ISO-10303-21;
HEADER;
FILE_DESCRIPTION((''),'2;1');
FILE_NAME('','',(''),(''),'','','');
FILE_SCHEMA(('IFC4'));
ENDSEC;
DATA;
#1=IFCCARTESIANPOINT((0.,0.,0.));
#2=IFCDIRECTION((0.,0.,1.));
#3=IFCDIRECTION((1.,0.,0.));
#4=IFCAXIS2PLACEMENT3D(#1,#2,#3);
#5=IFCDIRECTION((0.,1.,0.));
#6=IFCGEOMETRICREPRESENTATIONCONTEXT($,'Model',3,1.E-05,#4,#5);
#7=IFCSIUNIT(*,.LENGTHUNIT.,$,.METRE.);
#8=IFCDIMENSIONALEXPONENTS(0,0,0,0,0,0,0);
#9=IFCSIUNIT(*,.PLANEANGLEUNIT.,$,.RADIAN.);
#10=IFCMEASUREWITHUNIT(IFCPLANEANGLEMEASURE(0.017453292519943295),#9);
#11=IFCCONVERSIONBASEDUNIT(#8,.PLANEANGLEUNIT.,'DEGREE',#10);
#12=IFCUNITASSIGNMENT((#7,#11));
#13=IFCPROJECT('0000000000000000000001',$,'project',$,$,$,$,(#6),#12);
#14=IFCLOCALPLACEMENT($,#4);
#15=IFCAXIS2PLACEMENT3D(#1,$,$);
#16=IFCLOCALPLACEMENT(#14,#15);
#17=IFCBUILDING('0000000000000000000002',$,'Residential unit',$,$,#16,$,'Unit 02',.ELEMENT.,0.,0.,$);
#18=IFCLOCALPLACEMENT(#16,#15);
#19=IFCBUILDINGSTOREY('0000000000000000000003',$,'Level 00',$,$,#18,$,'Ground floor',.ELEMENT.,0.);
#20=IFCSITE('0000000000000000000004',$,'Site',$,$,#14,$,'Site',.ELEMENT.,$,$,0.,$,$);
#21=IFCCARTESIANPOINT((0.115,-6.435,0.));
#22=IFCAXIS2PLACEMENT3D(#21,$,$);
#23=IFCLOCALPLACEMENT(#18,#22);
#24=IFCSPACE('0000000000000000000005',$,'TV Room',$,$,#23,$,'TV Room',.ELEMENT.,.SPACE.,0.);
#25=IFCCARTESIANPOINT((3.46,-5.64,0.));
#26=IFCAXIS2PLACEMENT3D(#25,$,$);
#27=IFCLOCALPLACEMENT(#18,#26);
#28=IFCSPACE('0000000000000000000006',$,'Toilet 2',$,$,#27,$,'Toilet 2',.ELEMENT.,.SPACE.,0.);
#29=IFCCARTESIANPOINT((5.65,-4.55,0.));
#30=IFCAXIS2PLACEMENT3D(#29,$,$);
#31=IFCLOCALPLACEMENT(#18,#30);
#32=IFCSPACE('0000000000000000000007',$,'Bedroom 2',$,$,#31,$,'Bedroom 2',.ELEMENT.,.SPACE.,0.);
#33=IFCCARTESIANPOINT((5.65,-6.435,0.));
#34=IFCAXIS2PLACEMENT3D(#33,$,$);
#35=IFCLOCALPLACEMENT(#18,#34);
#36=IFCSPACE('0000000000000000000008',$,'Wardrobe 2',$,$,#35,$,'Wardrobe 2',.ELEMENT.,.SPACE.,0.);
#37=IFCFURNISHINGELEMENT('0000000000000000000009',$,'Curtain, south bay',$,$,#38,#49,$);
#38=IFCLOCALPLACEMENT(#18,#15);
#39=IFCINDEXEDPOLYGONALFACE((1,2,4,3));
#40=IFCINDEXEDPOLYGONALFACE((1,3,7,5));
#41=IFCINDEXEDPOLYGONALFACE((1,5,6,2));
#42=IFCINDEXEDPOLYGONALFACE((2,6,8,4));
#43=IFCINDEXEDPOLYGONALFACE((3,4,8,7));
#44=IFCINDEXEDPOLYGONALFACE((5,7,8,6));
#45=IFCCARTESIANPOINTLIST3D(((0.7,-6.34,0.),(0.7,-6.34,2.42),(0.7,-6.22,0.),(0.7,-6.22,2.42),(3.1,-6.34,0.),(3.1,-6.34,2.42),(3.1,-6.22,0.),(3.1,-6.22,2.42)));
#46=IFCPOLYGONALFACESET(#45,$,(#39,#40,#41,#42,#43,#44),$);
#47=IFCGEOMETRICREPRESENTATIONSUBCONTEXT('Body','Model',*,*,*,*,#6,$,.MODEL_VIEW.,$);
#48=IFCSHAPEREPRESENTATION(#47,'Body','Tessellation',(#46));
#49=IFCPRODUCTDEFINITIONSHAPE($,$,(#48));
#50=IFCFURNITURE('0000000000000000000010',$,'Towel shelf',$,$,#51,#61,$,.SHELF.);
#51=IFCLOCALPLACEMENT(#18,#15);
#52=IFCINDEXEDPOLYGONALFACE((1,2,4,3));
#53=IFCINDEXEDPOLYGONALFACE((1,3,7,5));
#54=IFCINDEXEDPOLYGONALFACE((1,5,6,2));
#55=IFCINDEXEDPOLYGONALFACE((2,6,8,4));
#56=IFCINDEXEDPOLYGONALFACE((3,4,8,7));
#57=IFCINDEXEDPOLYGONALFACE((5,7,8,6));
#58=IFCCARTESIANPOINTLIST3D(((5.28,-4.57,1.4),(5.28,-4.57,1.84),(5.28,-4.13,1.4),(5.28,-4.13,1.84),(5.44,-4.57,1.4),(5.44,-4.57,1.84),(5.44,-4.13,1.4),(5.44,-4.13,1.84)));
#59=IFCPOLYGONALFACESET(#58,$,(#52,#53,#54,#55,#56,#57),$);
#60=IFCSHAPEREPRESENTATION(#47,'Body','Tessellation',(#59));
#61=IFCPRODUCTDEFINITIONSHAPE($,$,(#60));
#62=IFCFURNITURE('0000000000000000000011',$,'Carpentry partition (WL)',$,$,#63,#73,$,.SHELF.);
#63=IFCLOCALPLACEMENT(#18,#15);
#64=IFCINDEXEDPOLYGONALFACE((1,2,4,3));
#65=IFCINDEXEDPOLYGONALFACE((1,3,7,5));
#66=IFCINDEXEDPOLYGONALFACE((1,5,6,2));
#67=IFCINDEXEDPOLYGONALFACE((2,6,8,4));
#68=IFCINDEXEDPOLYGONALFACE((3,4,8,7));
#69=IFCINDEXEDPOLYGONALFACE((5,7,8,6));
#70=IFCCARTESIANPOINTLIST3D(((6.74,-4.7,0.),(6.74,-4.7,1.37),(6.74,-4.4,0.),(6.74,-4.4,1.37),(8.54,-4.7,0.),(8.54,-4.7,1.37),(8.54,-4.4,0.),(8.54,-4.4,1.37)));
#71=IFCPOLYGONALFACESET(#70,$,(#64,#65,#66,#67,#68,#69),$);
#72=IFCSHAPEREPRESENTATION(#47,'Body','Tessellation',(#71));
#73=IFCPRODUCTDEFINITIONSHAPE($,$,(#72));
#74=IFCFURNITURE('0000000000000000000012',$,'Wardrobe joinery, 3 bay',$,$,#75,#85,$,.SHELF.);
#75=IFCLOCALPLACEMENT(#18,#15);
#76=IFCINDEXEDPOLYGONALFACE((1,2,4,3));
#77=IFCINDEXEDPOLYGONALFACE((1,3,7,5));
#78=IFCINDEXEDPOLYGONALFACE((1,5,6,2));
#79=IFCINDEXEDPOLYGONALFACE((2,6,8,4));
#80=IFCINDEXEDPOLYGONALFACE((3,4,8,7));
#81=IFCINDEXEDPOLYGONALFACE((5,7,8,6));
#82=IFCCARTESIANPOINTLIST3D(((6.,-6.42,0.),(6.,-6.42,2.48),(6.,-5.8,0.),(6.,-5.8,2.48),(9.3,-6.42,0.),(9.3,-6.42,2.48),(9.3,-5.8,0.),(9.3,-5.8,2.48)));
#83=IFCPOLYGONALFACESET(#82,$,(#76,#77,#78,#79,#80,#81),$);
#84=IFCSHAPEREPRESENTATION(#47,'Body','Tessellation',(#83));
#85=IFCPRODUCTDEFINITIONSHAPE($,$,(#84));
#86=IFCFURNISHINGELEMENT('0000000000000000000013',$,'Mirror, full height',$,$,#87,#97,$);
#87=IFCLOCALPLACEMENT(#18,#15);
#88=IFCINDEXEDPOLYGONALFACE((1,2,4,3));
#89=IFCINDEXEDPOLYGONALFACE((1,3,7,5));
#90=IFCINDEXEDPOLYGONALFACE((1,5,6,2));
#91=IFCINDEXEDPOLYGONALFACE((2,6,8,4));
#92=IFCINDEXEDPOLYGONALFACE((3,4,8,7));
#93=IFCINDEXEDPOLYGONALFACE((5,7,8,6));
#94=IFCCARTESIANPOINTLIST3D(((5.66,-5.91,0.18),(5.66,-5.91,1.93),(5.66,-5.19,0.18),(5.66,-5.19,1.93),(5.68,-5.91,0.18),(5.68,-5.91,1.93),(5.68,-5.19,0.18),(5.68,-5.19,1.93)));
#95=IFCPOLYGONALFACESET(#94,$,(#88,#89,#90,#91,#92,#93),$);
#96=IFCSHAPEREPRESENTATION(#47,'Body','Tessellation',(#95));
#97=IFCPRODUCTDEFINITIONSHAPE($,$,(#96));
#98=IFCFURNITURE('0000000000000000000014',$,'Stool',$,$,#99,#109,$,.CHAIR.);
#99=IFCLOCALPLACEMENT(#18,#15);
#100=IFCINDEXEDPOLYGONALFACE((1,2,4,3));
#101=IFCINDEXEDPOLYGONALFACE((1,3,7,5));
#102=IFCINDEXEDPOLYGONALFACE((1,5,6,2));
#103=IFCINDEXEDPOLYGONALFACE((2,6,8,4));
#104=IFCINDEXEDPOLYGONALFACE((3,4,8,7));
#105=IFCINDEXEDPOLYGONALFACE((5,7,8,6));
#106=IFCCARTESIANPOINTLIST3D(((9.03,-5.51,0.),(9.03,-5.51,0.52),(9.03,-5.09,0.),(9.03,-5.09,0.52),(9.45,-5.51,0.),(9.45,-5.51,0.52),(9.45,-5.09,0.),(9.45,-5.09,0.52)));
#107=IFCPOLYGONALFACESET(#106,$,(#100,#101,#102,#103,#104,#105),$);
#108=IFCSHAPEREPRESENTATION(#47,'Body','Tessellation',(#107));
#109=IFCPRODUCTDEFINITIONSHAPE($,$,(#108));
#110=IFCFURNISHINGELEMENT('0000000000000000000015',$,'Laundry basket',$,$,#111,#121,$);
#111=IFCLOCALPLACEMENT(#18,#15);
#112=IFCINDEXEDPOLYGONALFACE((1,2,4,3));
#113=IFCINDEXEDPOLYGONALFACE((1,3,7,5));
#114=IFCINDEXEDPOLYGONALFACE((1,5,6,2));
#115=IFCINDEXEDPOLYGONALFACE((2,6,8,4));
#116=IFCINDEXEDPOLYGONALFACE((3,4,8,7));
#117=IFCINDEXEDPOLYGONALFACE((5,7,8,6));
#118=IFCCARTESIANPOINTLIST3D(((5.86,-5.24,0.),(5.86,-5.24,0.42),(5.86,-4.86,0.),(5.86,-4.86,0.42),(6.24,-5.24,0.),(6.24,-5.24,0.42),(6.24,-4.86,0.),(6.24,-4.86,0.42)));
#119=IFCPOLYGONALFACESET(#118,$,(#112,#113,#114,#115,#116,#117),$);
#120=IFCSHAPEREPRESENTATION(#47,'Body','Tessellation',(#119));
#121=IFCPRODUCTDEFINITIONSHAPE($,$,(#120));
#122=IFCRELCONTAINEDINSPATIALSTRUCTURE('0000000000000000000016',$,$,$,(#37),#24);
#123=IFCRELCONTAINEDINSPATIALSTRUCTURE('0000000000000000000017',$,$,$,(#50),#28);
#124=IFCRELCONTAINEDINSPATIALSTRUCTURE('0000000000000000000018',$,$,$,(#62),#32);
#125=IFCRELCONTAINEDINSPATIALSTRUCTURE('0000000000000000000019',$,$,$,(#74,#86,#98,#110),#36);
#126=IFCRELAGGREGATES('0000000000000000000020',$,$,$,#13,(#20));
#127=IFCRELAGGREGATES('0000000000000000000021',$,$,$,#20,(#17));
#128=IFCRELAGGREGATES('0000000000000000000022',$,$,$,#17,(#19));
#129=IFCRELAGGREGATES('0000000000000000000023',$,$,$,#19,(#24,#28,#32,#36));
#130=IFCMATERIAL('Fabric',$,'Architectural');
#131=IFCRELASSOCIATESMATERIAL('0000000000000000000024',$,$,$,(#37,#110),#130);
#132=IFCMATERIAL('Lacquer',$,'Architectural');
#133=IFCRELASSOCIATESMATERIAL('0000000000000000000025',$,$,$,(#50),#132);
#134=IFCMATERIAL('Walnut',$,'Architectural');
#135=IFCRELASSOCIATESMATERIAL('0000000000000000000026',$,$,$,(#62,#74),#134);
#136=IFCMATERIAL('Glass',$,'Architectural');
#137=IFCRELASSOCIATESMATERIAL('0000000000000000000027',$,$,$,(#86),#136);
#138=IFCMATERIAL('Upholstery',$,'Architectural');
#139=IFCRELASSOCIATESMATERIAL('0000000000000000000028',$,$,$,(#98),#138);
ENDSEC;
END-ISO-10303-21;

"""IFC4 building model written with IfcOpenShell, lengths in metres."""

from ifc_helpers import new_model, entity, si_unit, converted_unit, direction, frame, frame_2d, origin, origin_with_axes, place, context, subcontext, project, spatial, rectangle, extrude, material, element, save


model = new_model("IFC4")

# Units and contexts
model_context = context("Model", 3, precision=1e-05, world=origin_with_axes(), true_north=direction((0.0, 1.0, 0.0)))
body_context = subcontext(model_context, "Body", "Model", "MODEL_VIEW")
ifc_project = project(units=[si_unit("LENGTHUNIT", "METRE"), converted_unit("PLANEANGLEUNIT", "DEGREE", entity("IfcPlaneAngleMeasure", 0.017453292519943295), si_unit("PLANEANGLEUNIT", "RADIAN"), dimensions=[0, 0, 0, 0, 0, 0, 0])], contexts=[model_context])

# Site, building, storey
site_placement = place(None, origin_with_axes())
site = spatial("IfcSite", under=ifc_project, at=site_placement, Name="Site", LongName="Site", CompositionType="ELEMENT", RefElevation=0.0)
building_placement = place(site_placement, origin())
building = spatial("IfcBuilding", under=site, at=building_placement, Name="Residential unit", LongName="Unit 02", CompositionType="ELEMENT", ElevationOfRefHeight=0.0, ElevationOfTerrain=0.0)
storey_placement = place(building_placement, origin())
storey = spatial("IfcBuildingStorey", under=building, at=storey_placement, Name="Level 00", LongName="Ground floor", CompositionType="ELEMENT", Elevation=0.0)

# Shared definitions
space_1_placement = place(storey_placement, frame((0.115, -6.435, 0.0)))
space_1 = spatial("IfcSpace", under=storey, at=space_1_placement, Name="TV Room", LongName="TV Room", CompositionType="ELEMENT", PredefinedType="SPACE", ElevationWithFlooring=0.0)

# Shared definitions
space_2_placement = place(storey_placement, frame((3.46, -5.64, 0.0)))
space_2 = spatial("IfcSpace", under=storey, at=space_2_placement, Name="Toilet 2", LongName="Toilet 2", CompositionType="ELEMENT", PredefinedType="SPACE", ElevationWithFlooring=0.0)

# Shared definitions
space_3_placement = place(storey_placement, frame((5.65, -4.55, 0.0)))
space_3 = spatial("IfcSpace", under=storey, at=space_3_placement, Name="Bedroom 2", LongName="Bedroom 2", CompositionType="ELEMENT", PredefinedType="SPACE", ElevationWithFlooring=0.0)

# Shared definitions
space_4_placement = place(storey_placement, frame((5.65, -6.435, 0.0)))
space_4 = spatial("IfcSpace", under=storey, at=space_4_placement, Name="Wardrobe 2", LongName="Wardrobe 2", CompositionType="ELEMENT", PredefinedType="SPACE", ElevationWithFlooring=0.0)

# Shared definitions
ifc_material_1 = material(Name="Upholstery", Category="Architectural")
ifc_material_2 = material(Name="Walnut", Category="Architectural")

# Furnishing element
ifc_material_3 = material(Name="Fabric", Category="Architectural")
furnishing_1_placement = place(storey_placement, frame((0.7, -6.34, 0.0)))
element("IfcFurnishingElement", 1, at=furnishing_1_placement, inside=space_1, material=ifc_material_3, Name="Curtain, south bay", context=body_context, shape_type="SweptSolid", body=[
    extrude(rectangle(XDim=2.4, YDim=0.12, at=frame_2d((1.2, 0.06))), origin(), (0.0, 0.0, 1.0), 2.42),
])

# Furniture
ifc_material_4 = material(Name="Lacquer", Category="Architectural")
furniture_1_placement = place(storey_placement, frame((5.28, -4.57, 1.4)))
element("IfcFurniture", 2, at=furniture_1_placement, inside=space_2, material=ifc_material_4, Name="Towel shelf", PredefinedType="SHELF", context=body_context, shape_type="SweptSolid", body=[
    extrude(rectangle(XDim=0.16, YDim=0.44, at=frame_2d((0.08, 0.22))), origin(), (0.0, 0.0, 1.0), 0.44),
])
furniture_2_placement = place(storey_placement, frame((6.74, -4.7, 0.0)))
element("IfcFurniture", 3, at=furniture_2_placement, inside=space_3, material=ifc_material_2, Name="Carpentry partition (WL)", PredefinedType="SHELF", context=body_context, shape_type="SweptSolid", body=[
    extrude(rectangle(XDim=1.8, YDim=0.3, at=frame_2d((0.9, 0.15))), origin(), (0.0, 0.0, 1.0), 1.37),
])
furniture_3_placement = place(storey_placement, frame((6.0, -6.42, 0.0)))
element("IfcFurniture", 4, at=furniture_3_placement, inside=space_4, material=ifc_material_2, Name="Wardrobe joinery, 3 bay", PredefinedType="SHELF", context=body_context, shape_type="SweptSolid", body=[
    extrude(rectangle(XDim=3.3, YDim=0.62, at=frame_2d((1.65, 0.31))), origin(), (0.0, 0.0, 1.0), 2.48),
])

# Furnishing element
ifc_material_5 = material(Name="Glass", Category="Architectural")
furnishing_2_placement = place(storey_placement, frame((5.66, -5.91, 0.18)))
element("IfcFurnishingElement", 5, at=furnishing_2_placement, inside=space_4, material=ifc_material_5, Name="Mirror, full height", context=body_context, shape_type="SweptSolid", body=[
    extrude(rectangle(XDim=0.02, YDim=0.72, at=frame_2d((0.01, 0.36))), origin(), (0.0, 0.0, 1.0), 1.75),
])

# Furniture
furniture_4_placement = place(storey_placement, frame((9.03, -5.51, 0.0)))
element("IfcFurniture", 6, at=furniture_4_placement, inside=space_4, material=ifc_material_1, Name="Stool", PredefinedType="CHAIR", context=body_context, shape_type="SweptSolid", body=[
    extrude(rectangle(XDim=0.42, YDim=0.42, at=frame_2d((0.21, 0.21))), origin(), (0.0, 0.0, 1.0), 0.52),
])

# Furnishing element
furnishing_3_placement = place(storey_placement, frame((5.86, -5.24, 0.0)))
element("IfcFurnishingElement", 7, at=furnishing_3_placement, inside=space_4, material=ifc_material_3, Name="Laundry basket", context=body_context, shape_type="SweptSolid", body=[
    extrude(rectangle(XDim=0.38, YDim=0.38, at=frame_2d((0.19, 0.19))), origin(), (0.0, 0.0, 1.0), 0.42),
])

save(model, "model.ifc")
